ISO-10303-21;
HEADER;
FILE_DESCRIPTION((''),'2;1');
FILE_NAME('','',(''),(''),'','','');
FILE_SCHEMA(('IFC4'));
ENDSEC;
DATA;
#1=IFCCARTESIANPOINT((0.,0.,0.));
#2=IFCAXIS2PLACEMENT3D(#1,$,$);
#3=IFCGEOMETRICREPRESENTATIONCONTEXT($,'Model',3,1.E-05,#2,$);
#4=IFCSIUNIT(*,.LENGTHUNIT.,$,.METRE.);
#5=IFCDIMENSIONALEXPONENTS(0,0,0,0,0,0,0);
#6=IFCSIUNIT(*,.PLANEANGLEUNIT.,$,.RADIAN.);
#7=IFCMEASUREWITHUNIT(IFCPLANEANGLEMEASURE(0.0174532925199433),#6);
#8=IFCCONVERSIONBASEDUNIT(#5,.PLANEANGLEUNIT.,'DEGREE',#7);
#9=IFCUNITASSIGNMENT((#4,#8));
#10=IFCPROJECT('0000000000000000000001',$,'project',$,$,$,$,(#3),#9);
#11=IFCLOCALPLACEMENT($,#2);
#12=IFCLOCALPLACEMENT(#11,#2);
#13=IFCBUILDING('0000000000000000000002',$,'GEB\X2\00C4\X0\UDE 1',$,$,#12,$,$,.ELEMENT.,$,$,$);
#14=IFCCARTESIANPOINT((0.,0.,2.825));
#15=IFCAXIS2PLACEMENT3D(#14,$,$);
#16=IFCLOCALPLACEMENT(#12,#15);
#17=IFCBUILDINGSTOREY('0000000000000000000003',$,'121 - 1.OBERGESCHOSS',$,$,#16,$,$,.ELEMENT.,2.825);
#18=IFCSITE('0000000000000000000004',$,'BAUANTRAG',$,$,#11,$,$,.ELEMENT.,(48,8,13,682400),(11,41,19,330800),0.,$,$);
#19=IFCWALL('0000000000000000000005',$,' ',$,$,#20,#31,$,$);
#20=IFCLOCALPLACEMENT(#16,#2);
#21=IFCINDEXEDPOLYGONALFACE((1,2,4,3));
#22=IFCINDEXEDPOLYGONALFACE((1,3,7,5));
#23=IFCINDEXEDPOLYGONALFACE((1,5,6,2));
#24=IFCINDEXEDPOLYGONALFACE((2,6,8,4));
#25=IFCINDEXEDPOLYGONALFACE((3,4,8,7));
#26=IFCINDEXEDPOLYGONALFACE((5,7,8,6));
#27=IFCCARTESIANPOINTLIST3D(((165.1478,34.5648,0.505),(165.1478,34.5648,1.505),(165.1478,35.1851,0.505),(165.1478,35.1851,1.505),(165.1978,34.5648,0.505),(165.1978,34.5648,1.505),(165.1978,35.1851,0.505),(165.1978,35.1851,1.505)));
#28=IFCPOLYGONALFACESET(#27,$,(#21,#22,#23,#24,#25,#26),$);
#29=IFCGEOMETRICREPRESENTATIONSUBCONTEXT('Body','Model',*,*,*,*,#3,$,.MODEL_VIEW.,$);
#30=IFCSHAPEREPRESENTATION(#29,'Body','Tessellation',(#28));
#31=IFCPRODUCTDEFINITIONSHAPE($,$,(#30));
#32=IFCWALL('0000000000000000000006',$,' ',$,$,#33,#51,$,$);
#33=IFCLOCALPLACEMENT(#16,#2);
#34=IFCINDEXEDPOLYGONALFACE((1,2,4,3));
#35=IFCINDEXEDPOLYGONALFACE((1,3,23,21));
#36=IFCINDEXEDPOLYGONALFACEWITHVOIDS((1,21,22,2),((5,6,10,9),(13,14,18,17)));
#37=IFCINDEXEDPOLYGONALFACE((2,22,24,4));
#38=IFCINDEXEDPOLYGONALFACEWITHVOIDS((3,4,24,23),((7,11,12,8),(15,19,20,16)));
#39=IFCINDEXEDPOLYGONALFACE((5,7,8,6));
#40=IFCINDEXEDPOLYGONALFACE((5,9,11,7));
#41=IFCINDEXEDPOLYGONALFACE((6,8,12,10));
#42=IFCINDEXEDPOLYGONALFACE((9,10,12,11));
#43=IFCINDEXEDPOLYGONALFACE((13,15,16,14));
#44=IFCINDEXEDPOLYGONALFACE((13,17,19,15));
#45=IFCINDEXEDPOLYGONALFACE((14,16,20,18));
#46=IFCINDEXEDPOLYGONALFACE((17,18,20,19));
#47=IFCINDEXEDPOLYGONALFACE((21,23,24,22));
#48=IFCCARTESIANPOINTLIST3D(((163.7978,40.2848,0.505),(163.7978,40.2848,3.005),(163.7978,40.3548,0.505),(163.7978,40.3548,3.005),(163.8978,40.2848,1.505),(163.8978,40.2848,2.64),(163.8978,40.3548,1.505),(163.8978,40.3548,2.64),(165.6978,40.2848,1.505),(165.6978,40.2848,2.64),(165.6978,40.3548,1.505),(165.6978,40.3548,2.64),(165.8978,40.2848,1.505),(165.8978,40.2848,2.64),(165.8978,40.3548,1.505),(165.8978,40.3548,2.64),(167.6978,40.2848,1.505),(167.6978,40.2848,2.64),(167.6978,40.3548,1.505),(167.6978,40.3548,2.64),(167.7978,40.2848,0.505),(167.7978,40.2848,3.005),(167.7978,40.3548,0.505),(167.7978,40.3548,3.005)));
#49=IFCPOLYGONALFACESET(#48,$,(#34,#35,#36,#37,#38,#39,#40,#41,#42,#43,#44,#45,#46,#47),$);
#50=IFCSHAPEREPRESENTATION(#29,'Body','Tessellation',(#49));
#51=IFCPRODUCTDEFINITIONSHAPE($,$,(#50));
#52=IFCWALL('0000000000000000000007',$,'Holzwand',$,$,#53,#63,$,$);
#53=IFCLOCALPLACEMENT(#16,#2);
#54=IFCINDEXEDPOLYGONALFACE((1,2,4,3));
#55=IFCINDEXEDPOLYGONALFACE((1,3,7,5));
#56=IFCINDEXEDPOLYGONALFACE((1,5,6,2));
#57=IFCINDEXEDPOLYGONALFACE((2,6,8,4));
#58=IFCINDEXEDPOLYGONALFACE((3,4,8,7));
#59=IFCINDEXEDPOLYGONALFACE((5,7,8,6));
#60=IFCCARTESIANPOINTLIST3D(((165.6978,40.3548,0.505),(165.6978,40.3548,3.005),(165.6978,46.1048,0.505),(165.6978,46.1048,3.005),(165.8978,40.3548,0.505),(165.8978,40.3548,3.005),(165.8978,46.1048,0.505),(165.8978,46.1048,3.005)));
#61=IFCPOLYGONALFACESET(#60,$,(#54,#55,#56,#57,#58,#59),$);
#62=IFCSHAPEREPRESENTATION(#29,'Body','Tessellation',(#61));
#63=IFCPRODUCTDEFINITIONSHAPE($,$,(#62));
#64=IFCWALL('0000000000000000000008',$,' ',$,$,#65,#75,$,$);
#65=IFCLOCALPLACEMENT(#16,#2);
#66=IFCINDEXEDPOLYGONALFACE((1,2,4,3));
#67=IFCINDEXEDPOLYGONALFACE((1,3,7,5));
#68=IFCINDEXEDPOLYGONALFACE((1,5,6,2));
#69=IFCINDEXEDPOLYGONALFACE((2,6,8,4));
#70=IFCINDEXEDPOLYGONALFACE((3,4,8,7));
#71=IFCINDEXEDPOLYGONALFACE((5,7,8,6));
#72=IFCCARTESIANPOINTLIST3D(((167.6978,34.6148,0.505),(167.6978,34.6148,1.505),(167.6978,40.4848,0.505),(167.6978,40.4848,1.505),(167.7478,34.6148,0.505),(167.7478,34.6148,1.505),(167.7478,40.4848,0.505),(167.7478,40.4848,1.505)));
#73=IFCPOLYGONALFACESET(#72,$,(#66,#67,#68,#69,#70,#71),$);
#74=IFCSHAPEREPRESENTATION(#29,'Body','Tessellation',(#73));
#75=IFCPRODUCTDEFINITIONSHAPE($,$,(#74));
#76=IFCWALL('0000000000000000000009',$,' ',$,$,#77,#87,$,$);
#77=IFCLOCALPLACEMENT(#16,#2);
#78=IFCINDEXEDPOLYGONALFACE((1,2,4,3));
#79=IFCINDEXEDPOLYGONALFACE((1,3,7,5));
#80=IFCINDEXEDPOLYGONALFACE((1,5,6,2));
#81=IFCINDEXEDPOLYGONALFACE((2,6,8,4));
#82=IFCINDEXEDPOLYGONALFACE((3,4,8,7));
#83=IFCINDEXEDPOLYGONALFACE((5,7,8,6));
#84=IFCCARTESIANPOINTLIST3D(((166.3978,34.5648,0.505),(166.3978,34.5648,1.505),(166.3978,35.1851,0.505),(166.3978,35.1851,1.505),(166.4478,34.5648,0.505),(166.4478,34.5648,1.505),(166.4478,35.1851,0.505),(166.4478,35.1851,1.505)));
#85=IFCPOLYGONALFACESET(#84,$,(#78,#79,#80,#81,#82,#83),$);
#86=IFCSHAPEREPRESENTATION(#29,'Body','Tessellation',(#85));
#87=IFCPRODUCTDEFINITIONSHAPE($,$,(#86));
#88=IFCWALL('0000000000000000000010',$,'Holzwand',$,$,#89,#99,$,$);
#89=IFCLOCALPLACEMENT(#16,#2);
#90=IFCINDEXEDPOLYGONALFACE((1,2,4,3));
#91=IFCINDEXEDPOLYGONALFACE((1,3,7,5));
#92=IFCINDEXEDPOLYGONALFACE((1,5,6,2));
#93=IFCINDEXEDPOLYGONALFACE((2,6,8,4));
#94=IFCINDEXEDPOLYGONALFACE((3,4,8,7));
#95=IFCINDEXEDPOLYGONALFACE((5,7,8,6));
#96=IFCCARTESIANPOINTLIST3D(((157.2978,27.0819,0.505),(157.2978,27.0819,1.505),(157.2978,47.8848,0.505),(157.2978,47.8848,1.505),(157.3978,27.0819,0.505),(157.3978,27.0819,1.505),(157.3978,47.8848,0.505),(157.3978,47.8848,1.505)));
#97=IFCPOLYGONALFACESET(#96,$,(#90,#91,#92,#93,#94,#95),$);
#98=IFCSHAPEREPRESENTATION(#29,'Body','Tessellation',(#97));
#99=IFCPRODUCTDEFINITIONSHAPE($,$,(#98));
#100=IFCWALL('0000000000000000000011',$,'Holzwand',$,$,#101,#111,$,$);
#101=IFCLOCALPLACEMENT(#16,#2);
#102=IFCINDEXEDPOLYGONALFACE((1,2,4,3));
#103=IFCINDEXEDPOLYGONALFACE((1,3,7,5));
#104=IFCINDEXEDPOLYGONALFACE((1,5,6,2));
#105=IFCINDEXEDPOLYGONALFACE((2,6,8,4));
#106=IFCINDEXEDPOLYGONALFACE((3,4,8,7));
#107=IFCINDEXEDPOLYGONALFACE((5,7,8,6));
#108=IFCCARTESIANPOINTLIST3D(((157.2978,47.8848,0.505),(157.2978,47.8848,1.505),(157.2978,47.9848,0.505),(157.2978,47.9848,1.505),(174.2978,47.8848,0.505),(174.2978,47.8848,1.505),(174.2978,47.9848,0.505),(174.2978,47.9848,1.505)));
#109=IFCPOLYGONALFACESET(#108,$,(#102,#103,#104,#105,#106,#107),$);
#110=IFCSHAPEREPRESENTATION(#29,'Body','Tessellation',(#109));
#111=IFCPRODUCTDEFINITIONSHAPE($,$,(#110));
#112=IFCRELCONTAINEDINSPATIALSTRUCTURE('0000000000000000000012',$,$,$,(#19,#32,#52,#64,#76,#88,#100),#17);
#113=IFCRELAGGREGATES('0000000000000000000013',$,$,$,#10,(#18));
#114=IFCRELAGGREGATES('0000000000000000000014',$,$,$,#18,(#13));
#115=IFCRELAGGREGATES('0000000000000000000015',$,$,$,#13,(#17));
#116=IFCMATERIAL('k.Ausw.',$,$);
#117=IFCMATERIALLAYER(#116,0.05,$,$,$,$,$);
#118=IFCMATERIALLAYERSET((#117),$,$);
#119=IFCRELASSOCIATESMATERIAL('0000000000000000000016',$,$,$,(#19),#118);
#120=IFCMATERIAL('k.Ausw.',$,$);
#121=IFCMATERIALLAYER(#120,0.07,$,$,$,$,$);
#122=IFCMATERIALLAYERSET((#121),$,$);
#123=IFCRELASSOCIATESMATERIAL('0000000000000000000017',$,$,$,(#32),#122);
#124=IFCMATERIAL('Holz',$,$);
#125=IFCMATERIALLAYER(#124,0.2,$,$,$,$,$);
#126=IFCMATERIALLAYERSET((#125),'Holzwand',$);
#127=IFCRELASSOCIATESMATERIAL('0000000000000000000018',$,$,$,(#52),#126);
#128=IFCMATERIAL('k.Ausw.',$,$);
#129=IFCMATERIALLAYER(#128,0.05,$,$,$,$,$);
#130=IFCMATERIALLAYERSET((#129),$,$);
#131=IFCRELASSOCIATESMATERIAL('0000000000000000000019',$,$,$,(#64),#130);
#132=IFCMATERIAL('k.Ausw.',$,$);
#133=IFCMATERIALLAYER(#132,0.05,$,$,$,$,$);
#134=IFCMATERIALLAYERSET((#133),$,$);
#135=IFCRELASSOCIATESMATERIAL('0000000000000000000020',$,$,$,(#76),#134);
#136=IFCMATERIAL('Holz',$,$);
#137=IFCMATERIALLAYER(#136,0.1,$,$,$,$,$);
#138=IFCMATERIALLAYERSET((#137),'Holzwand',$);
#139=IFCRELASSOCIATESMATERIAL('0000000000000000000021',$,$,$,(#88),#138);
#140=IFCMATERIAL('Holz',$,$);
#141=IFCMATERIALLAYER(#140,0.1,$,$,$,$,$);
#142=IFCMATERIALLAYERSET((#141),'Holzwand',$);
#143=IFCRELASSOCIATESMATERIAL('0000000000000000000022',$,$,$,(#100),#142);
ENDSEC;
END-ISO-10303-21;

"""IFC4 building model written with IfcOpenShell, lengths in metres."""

from ifc_helpers import new_model, entity, si_unit, converted_unit, frame, frame_2d, origin, origin_with_axes, place, context, subcontext, project, spatial, polyline, rectangle, outline, extrude, material, layer, layer_set, layer_usage, element, save


model = new_model("IFC4")

# Units and contexts
model_context = context("Model", 3, precision=1e-05, world=origin())
body_context = subcontext(model_context, "Body", "Model", "MODEL_VIEW")
ifc_project = project(units=[si_unit("LENGTHUNIT", "METRE"), converted_unit("PLANEANGLEUNIT", "DEGREE", entity("IfcPlaneAngleMeasure", 0.0174532925199433), si_unit("PLANEANGLEUNIT", "RADIAN"), dimensions=[0, 0, 0, 0, 0, 0, 0])], contexts=[model_context])

# Site, building, storey
site_placement = place(None, origin())
site = spatial("IfcSite", under=ifc_project, at=site_placement, Name="BAUANTRAG", CompositionType="ELEMENT", RefLatitude=(48, 8, 13, 682400), RefLongitude=(11, 41, 19, 330800), RefElevation=0.0)
building_placement = place(site_placement, origin())
building = spatial("IfcBuilding", under=site, at=building_placement, Name="GEBÄUDE 1", CompositionType="ELEMENT")
storey_placement = place(building_placement, frame((0.0, 0.0, 2.825)))
storey = spatial("IfcBuildingStorey", under=building, at=storey_placement, Name="121 - 1.OBERGESCHOSS", CompositionType="ELEMENT", Elevation=2.825)

# Wall
ifc_material_1 = material(Name="k.Ausw.")
ifc_layer_1 = layer(ifc_material_1, 0.05)
ifc_layer_set_1 = layer_set([ifc_layer_1])
ifc_layer_usage_1 = layer_usage(ifc_layer_set_1, "AXIS2", "POSITIVE", 0.0)
wall_1_placement = place(storey_placement, frame((165.1478, 35.1851, 0.505), z_axis=(0.0, 0.0, 1.0), x_axis=(0.0, -1.0, 0.0)))
element("IfcWall", 1, at=wall_1_placement, inside=storey, material=ifc_layer_usage_1, Name=" ", context=body_context, shape_type="SweptSolid", body=[
    extrude(rectangle(XDim=0.6203, YDim=0.05, at=frame_2d((0.3101, 0.025), x_axis=(1.0, 0.0))), origin_with_axes(), (0.0, 0.0, 1.0), 1.0),
])

# Wall, openings
ifc_material_2 = material(Name="k.Ausw.")
ifc_layer_2 = layer(ifc_material_2, 0.07)
ifc_layer_set_2 = layer_set([ifc_layer_2])
ifc_layer_usage_2 = layer_usage(ifc_layer_set_2, "AXIS2", "POSITIVE", 0.0)
wall_2_placement = place(storey_placement, frame((167.7978, 40.3548, 0.505), z_axis=(0.0, 0.0, 1.0), x_axis=(-1.0, 0.0, 0.0)))
wall_2 = element("IfcWall", 2, at=wall_2_placement, inside=storey, material=ifc_layer_usage_2, Name=" ", context=body_context, shape_type="SweptSolid", body=[
    extrude(rectangle(XDim=4.0, YDim=0.07, at=frame_2d((2.0, 0.035), x_axis=(1.0, 0.0))), origin_with_axes(), (0.0, 0.0, 1.0), 2.5),
])
opening_1_placement = place(wall_2_placement, frame((2.1, 0.0, 1.0), z_axis=(0.0, 1.0, 0.0), x_axis=(0.0, 0.0, 1.0)))
element("IfcOpeningElement", 3, at=opening_1_placement, cuts=wall_2, ObjectType="Opening", context=body_context, shape_type="SweptSolid", body=[
    extrude(outline(polyline([(0.0, 1.8), (1.135, 1.8), (1.135, 0.0), (0.0, 0.0), (0.0, 1.8)])), origin_with_axes(), (0.0, 0.0, 1.0), 0.07),
])
opening_2_placement = place(wall_2_placement, frame((0.1, 0.0, 1.0), z_axis=(0.0, 1.0, 0.0), x_axis=(0.0, 0.0, 1.0)))
element("IfcOpeningElement", 4, at=opening_2_placement, cuts=wall_2, ObjectType="Opening", context=body_context, shape_type="SweptSolid", body=[
    extrude(outline(polyline([(0.0, 1.8), (1.135, 1.8), (1.135, 0.0), (0.0, 0.0), (0.0, 1.8)])), origin_with_axes(), (0.0, 0.0, 1.0), 0.07),
])

# Walls
ifc_material_3 = material(Name="Holz")
ifc_layer_3 = layer(ifc_material_3, 0.2)
ifc_layer_set_3 = layer_set([ifc_layer_3], Name="Holzwand")
ifc_layer_usage_3 = layer_usage(ifc_layer_set_3, "AXIS2", "POSITIVE", 0.0)
wall_3_placement = place(storey_placement, frame((165.6978, 46.1048, 0.505), z_axis=(0.0, 0.0, 1.0), x_axis=(0.0, -1.0, 0.0)))
element("IfcWall", 5, at=wall_3_placement, inside=storey, material=ifc_layer_usage_3, Name="Holzwand", context=body_context, shape_type="SweptSolid", body=[
    extrude(rectangle(XDim=5.75, YDim=0.2, at=frame_2d((2.875, 0.1), x_axis=(1.0, 0.0))), origin_with_axes(), (0.0, 0.0, 1.0), 2.5),
])
ifc_material_4 = material(Name="k.Ausw.")
ifc_layer_4 = layer(ifc_material_4, 0.05)
ifc_layer_set_4 = layer_set([ifc_layer_4])
ifc_layer_usage_4 = layer_usage(ifc_layer_set_4, "AXIS2", "POSITIVE", 0.0)
wall_4_placement = place(storey_placement, frame((167.7478, 34.6148, 0.505), z_axis=(0.0, 0.0, 1.0), x_axis=(0.0, 1.0, 0.0)))
element("IfcWall", 6, at=wall_4_placement, inside=storey, material=ifc_layer_usage_4, Name=" ", context=body_context, shape_type="SweptSolid", body=[
    extrude(rectangle(XDim=5.87, YDim=0.05, at=frame_2d((2.935, 0.025), x_axis=(1.0, 0.0))), origin_with_axes(), (0.0, 0.0, 1.0), 1.0),
])
ifc_material_5 = material(Name="k.Ausw.")
ifc_layer_5 = layer(ifc_material_5, 0.05)
ifc_layer_set_5 = layer_set([ifc_layer_5])
ifc_layer_usage_5 = layer_usage(ifc_layer_set_5, "AXIS2", "POSITIVE", 0.0)
wall_5_placement = place(storey_placement, frame((166.4478, 34.5648, 0.505), z_axis=(0.0, 0.0, 1.0), x_axis=(0.0, 1.0, 0.0)))
element("IfcWall", 7, at=wall_5_placement, inside=storey, material=ifc_layer_usage_5, Name=" ", context=body_context, shape_type="SweptSolid", body=[
    extrude(rectangle(XDim=0.6203, YDim=0.05, at=frame_2d((0.3101, 0.025), x_axis=(1.0, 0.0))), origin_with_axes(), (0.0, 0.0, 1.0), 1.0),
])
ifc_material_6 = material(Name="Holz")
ifc_layer_6 = layer(ifc_material_6, 0.1)
ifc_layer_set_6 = layer_set([ifc_layer_6], Name="Holzwand")
ifc_layer_usage_6 = layer_usage(ifc_layer_set_6, "AXIS2", "POSITIVE", 0.0)
wall_6_placement = place(storey_placement, frame((157.2978, 47.8848, 0.505), z_axis=(0.0, 0.0, 1.0), x_axis=(0.0, -1.0, 0.0)))
element("IfcWall", 8, at=wall_6_placement, inside=storey, material=ifc_layer_usage_6, Name="Holzwand", context=body_context, shape_type="SweptSolid", body=[
    extrude(rectangle(XDim=20.8029, YDim=0.1, at=frame_2d((10.4014, 0.05), x_axis=(1.0, 0.0))), origin_with_axes(), (0.0, 0.0, 1.0), 1.0),
])
ifc_material_7 = material(Name="Holz")
ifc_layer_7 = layer(ifc_material_7, 0.1)
ifc_layer_set_7 = layer_set([ifc_layer_7], Name="Holzwand")
ifc_layer_usage_7 = layer_usage(ifc_layer_set_7, "AXIS2", "POSITIVE", 0.0)
wall_7_placement = place(storey_placement, frame((174.2978, 47.9848, 0.505), z_axis=(0.0, 0.0, 1.0), x_axis=(-1.0, 0.0, 0.0)))
element("IfcWall", 9, at=wall_7_placement, inside=storey, material=ifc_layer_usage_7, Name="Holzwand", context=body_context, shape_type="SweptSolid", body=[
    extrude(rectangle(XDim=17.0, YDim=0.1, at=frame_2d((8.5, 0.05), x_axis=(1.0, 0.0))), origin_with_axes(), (0.0, 0.0, 1.0), 1.0),
])

save(model, "model.ifc")
